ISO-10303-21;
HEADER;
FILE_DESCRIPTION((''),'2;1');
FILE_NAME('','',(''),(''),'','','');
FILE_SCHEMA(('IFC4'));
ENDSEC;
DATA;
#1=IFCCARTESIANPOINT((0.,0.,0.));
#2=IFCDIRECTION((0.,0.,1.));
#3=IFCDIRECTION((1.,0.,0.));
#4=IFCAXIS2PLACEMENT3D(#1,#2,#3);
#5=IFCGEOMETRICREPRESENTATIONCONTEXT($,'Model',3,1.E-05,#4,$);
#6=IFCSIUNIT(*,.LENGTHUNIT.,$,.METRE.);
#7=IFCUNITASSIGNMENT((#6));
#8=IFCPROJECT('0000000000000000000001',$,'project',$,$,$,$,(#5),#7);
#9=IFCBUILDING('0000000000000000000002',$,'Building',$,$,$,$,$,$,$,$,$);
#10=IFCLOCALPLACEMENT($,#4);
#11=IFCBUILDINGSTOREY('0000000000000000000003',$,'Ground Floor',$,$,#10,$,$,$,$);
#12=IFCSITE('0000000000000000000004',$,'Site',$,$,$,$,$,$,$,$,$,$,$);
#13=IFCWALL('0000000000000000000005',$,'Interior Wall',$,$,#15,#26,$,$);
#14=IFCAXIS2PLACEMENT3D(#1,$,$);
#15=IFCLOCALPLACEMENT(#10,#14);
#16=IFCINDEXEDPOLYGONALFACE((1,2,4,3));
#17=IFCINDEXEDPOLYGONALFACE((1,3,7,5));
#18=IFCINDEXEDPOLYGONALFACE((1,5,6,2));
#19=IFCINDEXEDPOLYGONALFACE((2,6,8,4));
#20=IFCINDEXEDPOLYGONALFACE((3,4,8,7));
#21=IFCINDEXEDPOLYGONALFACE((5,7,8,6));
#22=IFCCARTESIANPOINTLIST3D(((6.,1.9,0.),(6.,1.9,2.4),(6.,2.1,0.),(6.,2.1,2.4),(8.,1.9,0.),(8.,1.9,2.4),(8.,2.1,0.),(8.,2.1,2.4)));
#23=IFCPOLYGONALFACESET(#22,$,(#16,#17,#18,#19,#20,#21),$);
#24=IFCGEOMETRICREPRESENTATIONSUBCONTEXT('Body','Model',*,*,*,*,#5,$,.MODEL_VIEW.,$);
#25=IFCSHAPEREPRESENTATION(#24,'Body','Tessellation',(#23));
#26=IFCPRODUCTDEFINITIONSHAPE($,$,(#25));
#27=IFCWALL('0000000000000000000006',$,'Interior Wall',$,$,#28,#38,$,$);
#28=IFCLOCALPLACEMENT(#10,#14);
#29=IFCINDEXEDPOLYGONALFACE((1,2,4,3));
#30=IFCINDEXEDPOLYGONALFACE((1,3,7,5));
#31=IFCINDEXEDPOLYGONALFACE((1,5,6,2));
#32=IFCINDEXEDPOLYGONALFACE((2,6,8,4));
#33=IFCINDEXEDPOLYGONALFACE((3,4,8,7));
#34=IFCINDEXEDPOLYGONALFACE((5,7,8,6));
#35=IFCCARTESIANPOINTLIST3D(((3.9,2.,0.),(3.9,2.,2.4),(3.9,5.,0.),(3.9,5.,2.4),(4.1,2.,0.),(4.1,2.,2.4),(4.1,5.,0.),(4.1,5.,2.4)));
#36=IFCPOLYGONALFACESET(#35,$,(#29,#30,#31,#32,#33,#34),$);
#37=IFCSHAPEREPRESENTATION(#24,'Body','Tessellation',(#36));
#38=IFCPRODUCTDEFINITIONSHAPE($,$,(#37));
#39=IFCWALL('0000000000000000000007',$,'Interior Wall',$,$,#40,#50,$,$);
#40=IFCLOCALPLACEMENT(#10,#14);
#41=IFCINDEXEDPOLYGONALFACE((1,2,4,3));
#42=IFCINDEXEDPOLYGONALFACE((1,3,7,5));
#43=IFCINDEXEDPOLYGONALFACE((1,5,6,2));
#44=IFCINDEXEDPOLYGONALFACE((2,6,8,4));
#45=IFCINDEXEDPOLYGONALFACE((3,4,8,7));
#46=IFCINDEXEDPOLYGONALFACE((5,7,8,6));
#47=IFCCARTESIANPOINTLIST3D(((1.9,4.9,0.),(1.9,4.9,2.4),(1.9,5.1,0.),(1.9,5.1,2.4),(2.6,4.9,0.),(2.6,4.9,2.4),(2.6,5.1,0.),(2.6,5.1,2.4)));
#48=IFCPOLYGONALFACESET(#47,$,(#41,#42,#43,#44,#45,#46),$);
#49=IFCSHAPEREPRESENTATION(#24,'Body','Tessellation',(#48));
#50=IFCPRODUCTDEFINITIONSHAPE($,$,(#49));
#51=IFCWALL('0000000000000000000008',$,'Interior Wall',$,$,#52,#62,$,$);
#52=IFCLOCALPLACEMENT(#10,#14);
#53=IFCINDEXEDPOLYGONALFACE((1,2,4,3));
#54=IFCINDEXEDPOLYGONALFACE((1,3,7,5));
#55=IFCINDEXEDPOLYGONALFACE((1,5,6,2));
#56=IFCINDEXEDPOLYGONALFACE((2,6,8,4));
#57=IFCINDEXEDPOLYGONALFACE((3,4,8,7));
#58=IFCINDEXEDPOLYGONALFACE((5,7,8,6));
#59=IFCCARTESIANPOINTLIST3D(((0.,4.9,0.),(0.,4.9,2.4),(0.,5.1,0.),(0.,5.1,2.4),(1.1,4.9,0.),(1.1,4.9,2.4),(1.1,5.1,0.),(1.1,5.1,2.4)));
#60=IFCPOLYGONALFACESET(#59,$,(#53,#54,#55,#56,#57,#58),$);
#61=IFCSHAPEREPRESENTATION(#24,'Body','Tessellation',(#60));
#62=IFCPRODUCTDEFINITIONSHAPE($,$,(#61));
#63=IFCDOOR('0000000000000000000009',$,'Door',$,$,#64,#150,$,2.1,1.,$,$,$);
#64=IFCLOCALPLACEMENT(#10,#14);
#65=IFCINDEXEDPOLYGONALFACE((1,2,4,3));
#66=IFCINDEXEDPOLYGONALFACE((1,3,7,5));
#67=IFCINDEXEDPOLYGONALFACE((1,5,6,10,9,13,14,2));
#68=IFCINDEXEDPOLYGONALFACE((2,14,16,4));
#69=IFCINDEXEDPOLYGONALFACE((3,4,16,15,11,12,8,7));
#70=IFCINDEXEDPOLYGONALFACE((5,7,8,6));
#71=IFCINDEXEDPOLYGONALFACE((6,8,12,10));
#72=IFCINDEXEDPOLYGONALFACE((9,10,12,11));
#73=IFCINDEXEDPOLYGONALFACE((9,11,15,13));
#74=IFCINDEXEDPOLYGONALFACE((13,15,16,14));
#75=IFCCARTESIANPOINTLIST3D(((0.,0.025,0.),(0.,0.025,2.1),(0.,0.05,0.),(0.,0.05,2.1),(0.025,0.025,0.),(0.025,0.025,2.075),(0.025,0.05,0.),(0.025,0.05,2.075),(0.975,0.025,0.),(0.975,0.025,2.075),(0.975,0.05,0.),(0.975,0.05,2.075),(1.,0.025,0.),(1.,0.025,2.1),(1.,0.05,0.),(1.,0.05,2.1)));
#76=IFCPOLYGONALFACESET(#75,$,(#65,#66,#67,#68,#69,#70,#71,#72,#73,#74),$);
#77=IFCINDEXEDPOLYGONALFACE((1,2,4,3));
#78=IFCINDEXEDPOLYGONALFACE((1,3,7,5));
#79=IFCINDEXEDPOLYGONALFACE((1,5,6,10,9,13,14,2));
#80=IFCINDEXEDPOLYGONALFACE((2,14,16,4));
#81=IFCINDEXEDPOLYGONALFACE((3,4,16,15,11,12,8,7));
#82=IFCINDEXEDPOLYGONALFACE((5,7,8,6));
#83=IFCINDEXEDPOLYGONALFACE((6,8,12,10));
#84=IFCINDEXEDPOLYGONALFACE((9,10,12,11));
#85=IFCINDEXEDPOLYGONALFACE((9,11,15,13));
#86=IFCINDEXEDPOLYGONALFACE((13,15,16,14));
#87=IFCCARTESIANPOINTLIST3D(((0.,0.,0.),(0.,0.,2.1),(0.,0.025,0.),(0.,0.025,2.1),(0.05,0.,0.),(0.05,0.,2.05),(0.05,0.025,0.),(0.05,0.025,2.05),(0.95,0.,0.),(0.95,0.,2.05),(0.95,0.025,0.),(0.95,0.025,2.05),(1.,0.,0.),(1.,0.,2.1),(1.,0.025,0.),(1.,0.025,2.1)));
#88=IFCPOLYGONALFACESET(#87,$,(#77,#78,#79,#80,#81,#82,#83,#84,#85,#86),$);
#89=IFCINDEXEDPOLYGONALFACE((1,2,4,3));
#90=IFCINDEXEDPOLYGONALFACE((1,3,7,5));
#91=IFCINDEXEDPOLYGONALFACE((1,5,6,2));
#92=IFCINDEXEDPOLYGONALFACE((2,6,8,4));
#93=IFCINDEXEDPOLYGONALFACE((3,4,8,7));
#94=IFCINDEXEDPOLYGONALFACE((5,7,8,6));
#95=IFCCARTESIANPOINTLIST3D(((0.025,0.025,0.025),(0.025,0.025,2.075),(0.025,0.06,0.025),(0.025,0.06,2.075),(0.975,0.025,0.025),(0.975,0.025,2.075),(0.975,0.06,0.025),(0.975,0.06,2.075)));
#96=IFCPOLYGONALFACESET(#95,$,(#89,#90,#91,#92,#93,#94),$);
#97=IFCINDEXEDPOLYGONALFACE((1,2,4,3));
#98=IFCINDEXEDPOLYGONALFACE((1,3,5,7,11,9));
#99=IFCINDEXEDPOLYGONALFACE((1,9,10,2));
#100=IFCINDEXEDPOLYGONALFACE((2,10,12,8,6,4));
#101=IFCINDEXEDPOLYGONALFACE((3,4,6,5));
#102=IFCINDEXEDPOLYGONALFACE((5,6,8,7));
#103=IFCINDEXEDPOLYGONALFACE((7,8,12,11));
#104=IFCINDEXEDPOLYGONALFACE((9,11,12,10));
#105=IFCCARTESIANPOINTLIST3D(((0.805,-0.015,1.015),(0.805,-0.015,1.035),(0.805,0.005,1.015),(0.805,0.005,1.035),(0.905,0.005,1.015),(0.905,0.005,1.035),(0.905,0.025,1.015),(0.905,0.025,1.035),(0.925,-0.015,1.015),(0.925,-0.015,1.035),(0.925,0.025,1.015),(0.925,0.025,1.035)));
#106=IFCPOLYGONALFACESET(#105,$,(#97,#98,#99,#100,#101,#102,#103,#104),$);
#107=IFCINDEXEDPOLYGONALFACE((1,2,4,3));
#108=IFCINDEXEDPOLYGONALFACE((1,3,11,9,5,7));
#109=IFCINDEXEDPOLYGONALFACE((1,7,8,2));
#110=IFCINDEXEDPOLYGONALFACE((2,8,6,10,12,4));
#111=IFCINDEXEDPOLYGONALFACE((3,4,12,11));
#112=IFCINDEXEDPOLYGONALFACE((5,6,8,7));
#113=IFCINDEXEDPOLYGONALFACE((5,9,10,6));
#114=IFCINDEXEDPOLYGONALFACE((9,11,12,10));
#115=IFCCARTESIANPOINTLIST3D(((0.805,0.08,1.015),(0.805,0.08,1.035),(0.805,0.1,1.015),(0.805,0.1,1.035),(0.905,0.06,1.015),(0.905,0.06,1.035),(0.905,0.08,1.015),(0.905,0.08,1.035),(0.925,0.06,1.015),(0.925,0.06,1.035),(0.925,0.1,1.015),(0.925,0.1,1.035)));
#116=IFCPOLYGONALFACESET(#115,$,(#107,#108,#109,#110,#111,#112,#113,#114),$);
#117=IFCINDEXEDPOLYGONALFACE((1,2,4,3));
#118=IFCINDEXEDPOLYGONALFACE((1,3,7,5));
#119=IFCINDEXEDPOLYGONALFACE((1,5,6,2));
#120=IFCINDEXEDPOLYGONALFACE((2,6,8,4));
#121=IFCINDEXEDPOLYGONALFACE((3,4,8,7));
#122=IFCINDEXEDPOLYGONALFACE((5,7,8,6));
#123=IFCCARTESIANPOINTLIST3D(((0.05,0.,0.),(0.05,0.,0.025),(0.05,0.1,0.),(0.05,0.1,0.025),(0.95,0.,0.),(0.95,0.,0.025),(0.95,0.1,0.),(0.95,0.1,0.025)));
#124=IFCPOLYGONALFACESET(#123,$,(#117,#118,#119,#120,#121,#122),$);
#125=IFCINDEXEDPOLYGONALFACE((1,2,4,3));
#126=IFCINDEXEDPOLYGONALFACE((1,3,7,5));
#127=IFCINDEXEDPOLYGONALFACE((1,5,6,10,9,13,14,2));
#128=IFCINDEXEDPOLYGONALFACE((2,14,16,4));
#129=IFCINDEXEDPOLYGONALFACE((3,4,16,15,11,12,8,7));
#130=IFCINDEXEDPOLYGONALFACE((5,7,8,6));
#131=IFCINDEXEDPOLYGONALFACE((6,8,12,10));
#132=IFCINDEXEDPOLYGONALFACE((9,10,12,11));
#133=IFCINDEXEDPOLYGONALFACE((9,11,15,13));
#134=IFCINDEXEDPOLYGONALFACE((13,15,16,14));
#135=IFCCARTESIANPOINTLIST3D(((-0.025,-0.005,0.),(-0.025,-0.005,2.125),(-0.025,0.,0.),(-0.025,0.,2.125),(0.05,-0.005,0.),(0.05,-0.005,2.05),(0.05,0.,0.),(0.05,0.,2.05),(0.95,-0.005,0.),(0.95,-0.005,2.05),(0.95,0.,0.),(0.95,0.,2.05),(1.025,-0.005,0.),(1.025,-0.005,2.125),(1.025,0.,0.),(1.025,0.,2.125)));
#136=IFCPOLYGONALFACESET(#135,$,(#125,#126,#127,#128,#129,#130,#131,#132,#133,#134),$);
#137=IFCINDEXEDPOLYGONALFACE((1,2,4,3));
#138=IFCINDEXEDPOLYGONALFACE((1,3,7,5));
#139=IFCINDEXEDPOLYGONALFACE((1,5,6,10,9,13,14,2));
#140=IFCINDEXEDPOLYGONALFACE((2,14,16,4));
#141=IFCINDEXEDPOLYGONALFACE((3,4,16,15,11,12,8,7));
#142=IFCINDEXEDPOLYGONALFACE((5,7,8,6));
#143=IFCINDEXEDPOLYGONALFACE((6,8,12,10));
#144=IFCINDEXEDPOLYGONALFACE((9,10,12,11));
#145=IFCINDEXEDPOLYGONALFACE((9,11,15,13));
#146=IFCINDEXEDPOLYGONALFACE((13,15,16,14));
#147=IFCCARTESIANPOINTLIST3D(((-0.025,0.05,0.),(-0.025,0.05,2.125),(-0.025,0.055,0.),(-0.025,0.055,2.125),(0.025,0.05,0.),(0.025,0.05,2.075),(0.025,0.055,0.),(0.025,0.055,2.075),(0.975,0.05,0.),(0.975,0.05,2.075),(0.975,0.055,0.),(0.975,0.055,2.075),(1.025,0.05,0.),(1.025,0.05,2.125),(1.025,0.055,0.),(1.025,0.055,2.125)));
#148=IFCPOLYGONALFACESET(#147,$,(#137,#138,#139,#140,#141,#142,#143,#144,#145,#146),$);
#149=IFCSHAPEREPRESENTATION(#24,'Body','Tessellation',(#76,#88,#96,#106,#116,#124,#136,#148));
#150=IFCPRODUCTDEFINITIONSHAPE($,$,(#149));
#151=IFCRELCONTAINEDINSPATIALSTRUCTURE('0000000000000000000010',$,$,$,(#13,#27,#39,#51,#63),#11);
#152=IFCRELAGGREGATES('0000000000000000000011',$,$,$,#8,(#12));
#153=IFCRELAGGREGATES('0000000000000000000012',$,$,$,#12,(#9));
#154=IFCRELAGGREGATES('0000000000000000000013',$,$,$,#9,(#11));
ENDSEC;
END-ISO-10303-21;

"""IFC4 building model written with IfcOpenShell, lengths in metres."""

from ifc_helpers import new_model, si_unit, frame, origin_with_axes, place, context, subcontext, project, spatial, line, indexed_curve, outline, extrude, element, save


model = new_model("IFC4")

# Units and contexts
model_context = context("Model", 3, precision=1e-05, world=origin_with_axes())
body_context = subcontext(model_context, "Body", "Model", "MODEL_VIEW")
ifc_project = project(units=[si_unit("LENGTHUNIT", "METRE")], contexts=[model_context])

# Site, building, storey
site = spatial("IfcSite", under=ifc_project, Name="Site")
building = spatial("IfcBuilding", under=site, Name="Building")
storey_placement = place(None, origin_with_axes())
storey = spatial("IfcBuildingStorey", under=building, at=storey_placement, Name="Ground Floor")

# Walls
wall_1_placement = place(storey_placement, frame((8.0, 2.0, 0.0), z_axis=(0.0, 0.0, 1.0), x_axis=(-1.0, 0.0, 0.0)))
element("IfcWall", 1, at=wall_1_placement, inside=storey, Name="Interior Wall", context=body_context, shape_type="SweptSolid", body=[
    extrude(outline(indexed_curve([(0.0, 0.0), (0.0, 0.2), (2.0, 0.2), (2.0, 0.0), (0.0, 0.0)], self_intersect=False)), frame((0.0, -0.1, 0.0), z_axis=(0.0, 0.0, 1.0), x_axis=(1.0, 0.0, 0.0)), (0.0, 0.0, 1.0), 2.4),
])
wall_2_placement = place(storey_placement, frame((4.0, 2.0, 0.0), z_axis=(0.0, 0.0, 1.0), x_axis=(0.0, 1.0, 0.0)))
element("IfcWall", 2, at=wall_2_placement, inside=storey, Name="Interior Wall", context=body_context, shape_type="SweptSolid", body=[
    extrude(outline(indexed_curve([(0.0, 0.0), (0.0, 0.2), (3.0, 0.2), (3.0, 0.0), (0.0, 0.0)], self_intersect=False)), frame((0.0, -0.1, 0.0), z_axis=(0.0, 0.0, 1.0), x_axis=(1.0, 0.0, 0.0)), (0.0, 0.0, 1.0), 2.4),
])
wall_3_placement = place(storey_placement, frame((2.6, 5.0, 0.0), z_axis=(0.0, 0.0, 1.0), x_axis=(-1.0, 0.0, 0.0)))
element("IfcWall", 3, at=wall_3_placement, inside=storey, Name="Interior Wall", context=body_context, shape_type="SweptSolid", body=[
    extrude(outline(indexed_curve([(0.0, 0.0), (0.0, 0.2), (0.7, 0.2), (0.7, 0.0), (0.0, 0.0)], self_intersect=False)), frame((0.0, -0.1, 0.0), z_axis=(0.0, 0.0, 1.0), x_axis=(1.0, 0.0, 0.0)), (0.0, 0.0, 1.0), 2.4),
])
wall_4_placement = place(storey_placement, frame((1.1, 5.0, 0.0), z_axis=(0.0, 0.0, 1.0), x_axis=(-1.0, 0.0, 0.0)))
element("IfcWall", 4, at=wall_4_placement, inside=storey, Name="Interior Wall", context=body_context, shape_type="SweptSolid", body=[
    extrude(outline(indexed_curve([(0.0, 0.0), (0.0, 0.2), (1.1, 0.2), (1.1, 0.0), (0.0, 0.0)], self_intersect=False)), frame((0.0, -0.1, 0.0), z_axis=(0.0, 0.0, 1.0), x_axis=(1.0, 0.0, 0.0)), (0.0, 0.0, 1.0), 2.4),
])

# Door
door_1_placement = place(storey_placement, origin_with_axes())
element("IfcDoor", 5, at=door_1_placement, inside=storey, Name="Door", OverallHeight=2.1, OverallWidth=1.0, context=body_context, shape_type="SweptSolid", body=[
    extrude(outline(indexed_curve([(0.0, 0.0), (0.0, 2.1), (1.0, 2.1), (1.0, 0.0), (0.975, 0.0), (0.975, 2.075), (0.025, 2.075), (0.025, 0.0)], segments=[line(1, 2, 3, 4, 5, 6, 7, 8, 1)])), frame((0.0, 0.025, 0.0), z_axis=(0.0, -1.0, 0.0), x_axis=(1.0, 0.0, 0.0)), (0.0, 0.0, -1.0), 0.025),
    extrude(outline(indexed_curve([(0.0, 0.0), (0.0, 2.1), (1.0, 2.1), (1.0, 0.0), (0.95, 0.0), (0.95, 2.05), (0.05, 2.05), (0.05, 0.0)], segments=[line(1, 2, 3, 4, 5, 6, 7, 8, 1)])), frame((0.0, 0.0, 0.0), z_axis=(0.0, -1.0, 0.0), x_axis=(1.0, 0.0, 0.0)), (0.0, 0.0, -1.0), 0.025),
    extrude(outline(indexed_curve([(0.0, 0.0), (0.95, 0.0), (0.95, 0.035), (0.0, 0.035)], segments=[line(1, 2, 3, 4, 1)])), frame((0.025, 0.025, 0.025), z_axis=(0.0, 0.0, 1.0), x_axis=(1.0, 0.0, 0.0)), (0.0, 0.0, 1.0), 2.05),
    extrude(outline(indexed_curve([(0.0, 0.0), (0.0, -0.04), (-0.12, -0.04), (-0.12, -0.02), (-0.02, -0.02), (-0.02, 0.0)], segments=[line(1, 2, 3, 4, 5, 6, 1)])), frame((0.925, 0.025, 1.015), z_axis=(0.0, 0.0, 1.0), x_axis=(1.0, 0.0, 0.0)), (0.0, 0.0, 1.0), 0.02),
    extrude(outline(indexed_curve([(0.0, 0.0), (0.0, 0.04), (-0.12, 0.04), (-0.12, 0.02), (-0.02, 0.02), (-0.02, 0.0)], segments=[line(1, 2, 3, 4, 5, 6, 1)])), frame((0.925, 0.06, 1.015), z_axis=(0.0, 0.0, 1.0), x_axis=(1.0, 0.0, 0.0)), (0.0, 0.0, 1.0), 0.02),
    extrude(outline(indexed_curve([(0.0, 0.0), (0.9, 0.0), (0.9, 0.1), (0.0, 0.1)], segments=[line(1, 2, 3, 4, 1)])), frame((0.05, 0.0, 0.0), z_axis=(0.0, 0.0, 1.0), x_axis=(1.0, 0.0, 0.0)), (0.0, 0.0, 1.0), 0.025),
    extrude(outline(indexed_curve([(0.0, 0.0), (0.0, 2.125), (1.05, 2.125), (1.05, 0.0), (0.975, 0.0), (0.975, 2.05), (0.075, 2.05), (0.075, 0.0)], segments=[line(1, 2, 3, 4, 5, 6, 7, 8, 1)])), frame((-0.025, -0.005, 0.0), z_axis=(0.0, -1.0, 0.0), x_axis=(1.0, 0.0, 0.0)), (0.0, 0.0, -1.0), 0.005),
    extrude(outline(indexed_curve([(0.0, 0.0), (0.0, 2.125), (1.05, 2.125), (1.05, 0.0), (1.0, 0.0), (1.0, 2.075), (0.05, 2.075), (0.05, 0.0)], segments=[line(1, 2, 3, 4, 5, 6, 7, 8, 1)])), frame((-0.025, 0.05, 0.0), z_axis=(0.0, -1.0, 0.0), x_axis=(1.0, 0.0, 0.0)), (0.0, 0.0, -1.0), 0.005),
])

save(model, "model.ifc")
